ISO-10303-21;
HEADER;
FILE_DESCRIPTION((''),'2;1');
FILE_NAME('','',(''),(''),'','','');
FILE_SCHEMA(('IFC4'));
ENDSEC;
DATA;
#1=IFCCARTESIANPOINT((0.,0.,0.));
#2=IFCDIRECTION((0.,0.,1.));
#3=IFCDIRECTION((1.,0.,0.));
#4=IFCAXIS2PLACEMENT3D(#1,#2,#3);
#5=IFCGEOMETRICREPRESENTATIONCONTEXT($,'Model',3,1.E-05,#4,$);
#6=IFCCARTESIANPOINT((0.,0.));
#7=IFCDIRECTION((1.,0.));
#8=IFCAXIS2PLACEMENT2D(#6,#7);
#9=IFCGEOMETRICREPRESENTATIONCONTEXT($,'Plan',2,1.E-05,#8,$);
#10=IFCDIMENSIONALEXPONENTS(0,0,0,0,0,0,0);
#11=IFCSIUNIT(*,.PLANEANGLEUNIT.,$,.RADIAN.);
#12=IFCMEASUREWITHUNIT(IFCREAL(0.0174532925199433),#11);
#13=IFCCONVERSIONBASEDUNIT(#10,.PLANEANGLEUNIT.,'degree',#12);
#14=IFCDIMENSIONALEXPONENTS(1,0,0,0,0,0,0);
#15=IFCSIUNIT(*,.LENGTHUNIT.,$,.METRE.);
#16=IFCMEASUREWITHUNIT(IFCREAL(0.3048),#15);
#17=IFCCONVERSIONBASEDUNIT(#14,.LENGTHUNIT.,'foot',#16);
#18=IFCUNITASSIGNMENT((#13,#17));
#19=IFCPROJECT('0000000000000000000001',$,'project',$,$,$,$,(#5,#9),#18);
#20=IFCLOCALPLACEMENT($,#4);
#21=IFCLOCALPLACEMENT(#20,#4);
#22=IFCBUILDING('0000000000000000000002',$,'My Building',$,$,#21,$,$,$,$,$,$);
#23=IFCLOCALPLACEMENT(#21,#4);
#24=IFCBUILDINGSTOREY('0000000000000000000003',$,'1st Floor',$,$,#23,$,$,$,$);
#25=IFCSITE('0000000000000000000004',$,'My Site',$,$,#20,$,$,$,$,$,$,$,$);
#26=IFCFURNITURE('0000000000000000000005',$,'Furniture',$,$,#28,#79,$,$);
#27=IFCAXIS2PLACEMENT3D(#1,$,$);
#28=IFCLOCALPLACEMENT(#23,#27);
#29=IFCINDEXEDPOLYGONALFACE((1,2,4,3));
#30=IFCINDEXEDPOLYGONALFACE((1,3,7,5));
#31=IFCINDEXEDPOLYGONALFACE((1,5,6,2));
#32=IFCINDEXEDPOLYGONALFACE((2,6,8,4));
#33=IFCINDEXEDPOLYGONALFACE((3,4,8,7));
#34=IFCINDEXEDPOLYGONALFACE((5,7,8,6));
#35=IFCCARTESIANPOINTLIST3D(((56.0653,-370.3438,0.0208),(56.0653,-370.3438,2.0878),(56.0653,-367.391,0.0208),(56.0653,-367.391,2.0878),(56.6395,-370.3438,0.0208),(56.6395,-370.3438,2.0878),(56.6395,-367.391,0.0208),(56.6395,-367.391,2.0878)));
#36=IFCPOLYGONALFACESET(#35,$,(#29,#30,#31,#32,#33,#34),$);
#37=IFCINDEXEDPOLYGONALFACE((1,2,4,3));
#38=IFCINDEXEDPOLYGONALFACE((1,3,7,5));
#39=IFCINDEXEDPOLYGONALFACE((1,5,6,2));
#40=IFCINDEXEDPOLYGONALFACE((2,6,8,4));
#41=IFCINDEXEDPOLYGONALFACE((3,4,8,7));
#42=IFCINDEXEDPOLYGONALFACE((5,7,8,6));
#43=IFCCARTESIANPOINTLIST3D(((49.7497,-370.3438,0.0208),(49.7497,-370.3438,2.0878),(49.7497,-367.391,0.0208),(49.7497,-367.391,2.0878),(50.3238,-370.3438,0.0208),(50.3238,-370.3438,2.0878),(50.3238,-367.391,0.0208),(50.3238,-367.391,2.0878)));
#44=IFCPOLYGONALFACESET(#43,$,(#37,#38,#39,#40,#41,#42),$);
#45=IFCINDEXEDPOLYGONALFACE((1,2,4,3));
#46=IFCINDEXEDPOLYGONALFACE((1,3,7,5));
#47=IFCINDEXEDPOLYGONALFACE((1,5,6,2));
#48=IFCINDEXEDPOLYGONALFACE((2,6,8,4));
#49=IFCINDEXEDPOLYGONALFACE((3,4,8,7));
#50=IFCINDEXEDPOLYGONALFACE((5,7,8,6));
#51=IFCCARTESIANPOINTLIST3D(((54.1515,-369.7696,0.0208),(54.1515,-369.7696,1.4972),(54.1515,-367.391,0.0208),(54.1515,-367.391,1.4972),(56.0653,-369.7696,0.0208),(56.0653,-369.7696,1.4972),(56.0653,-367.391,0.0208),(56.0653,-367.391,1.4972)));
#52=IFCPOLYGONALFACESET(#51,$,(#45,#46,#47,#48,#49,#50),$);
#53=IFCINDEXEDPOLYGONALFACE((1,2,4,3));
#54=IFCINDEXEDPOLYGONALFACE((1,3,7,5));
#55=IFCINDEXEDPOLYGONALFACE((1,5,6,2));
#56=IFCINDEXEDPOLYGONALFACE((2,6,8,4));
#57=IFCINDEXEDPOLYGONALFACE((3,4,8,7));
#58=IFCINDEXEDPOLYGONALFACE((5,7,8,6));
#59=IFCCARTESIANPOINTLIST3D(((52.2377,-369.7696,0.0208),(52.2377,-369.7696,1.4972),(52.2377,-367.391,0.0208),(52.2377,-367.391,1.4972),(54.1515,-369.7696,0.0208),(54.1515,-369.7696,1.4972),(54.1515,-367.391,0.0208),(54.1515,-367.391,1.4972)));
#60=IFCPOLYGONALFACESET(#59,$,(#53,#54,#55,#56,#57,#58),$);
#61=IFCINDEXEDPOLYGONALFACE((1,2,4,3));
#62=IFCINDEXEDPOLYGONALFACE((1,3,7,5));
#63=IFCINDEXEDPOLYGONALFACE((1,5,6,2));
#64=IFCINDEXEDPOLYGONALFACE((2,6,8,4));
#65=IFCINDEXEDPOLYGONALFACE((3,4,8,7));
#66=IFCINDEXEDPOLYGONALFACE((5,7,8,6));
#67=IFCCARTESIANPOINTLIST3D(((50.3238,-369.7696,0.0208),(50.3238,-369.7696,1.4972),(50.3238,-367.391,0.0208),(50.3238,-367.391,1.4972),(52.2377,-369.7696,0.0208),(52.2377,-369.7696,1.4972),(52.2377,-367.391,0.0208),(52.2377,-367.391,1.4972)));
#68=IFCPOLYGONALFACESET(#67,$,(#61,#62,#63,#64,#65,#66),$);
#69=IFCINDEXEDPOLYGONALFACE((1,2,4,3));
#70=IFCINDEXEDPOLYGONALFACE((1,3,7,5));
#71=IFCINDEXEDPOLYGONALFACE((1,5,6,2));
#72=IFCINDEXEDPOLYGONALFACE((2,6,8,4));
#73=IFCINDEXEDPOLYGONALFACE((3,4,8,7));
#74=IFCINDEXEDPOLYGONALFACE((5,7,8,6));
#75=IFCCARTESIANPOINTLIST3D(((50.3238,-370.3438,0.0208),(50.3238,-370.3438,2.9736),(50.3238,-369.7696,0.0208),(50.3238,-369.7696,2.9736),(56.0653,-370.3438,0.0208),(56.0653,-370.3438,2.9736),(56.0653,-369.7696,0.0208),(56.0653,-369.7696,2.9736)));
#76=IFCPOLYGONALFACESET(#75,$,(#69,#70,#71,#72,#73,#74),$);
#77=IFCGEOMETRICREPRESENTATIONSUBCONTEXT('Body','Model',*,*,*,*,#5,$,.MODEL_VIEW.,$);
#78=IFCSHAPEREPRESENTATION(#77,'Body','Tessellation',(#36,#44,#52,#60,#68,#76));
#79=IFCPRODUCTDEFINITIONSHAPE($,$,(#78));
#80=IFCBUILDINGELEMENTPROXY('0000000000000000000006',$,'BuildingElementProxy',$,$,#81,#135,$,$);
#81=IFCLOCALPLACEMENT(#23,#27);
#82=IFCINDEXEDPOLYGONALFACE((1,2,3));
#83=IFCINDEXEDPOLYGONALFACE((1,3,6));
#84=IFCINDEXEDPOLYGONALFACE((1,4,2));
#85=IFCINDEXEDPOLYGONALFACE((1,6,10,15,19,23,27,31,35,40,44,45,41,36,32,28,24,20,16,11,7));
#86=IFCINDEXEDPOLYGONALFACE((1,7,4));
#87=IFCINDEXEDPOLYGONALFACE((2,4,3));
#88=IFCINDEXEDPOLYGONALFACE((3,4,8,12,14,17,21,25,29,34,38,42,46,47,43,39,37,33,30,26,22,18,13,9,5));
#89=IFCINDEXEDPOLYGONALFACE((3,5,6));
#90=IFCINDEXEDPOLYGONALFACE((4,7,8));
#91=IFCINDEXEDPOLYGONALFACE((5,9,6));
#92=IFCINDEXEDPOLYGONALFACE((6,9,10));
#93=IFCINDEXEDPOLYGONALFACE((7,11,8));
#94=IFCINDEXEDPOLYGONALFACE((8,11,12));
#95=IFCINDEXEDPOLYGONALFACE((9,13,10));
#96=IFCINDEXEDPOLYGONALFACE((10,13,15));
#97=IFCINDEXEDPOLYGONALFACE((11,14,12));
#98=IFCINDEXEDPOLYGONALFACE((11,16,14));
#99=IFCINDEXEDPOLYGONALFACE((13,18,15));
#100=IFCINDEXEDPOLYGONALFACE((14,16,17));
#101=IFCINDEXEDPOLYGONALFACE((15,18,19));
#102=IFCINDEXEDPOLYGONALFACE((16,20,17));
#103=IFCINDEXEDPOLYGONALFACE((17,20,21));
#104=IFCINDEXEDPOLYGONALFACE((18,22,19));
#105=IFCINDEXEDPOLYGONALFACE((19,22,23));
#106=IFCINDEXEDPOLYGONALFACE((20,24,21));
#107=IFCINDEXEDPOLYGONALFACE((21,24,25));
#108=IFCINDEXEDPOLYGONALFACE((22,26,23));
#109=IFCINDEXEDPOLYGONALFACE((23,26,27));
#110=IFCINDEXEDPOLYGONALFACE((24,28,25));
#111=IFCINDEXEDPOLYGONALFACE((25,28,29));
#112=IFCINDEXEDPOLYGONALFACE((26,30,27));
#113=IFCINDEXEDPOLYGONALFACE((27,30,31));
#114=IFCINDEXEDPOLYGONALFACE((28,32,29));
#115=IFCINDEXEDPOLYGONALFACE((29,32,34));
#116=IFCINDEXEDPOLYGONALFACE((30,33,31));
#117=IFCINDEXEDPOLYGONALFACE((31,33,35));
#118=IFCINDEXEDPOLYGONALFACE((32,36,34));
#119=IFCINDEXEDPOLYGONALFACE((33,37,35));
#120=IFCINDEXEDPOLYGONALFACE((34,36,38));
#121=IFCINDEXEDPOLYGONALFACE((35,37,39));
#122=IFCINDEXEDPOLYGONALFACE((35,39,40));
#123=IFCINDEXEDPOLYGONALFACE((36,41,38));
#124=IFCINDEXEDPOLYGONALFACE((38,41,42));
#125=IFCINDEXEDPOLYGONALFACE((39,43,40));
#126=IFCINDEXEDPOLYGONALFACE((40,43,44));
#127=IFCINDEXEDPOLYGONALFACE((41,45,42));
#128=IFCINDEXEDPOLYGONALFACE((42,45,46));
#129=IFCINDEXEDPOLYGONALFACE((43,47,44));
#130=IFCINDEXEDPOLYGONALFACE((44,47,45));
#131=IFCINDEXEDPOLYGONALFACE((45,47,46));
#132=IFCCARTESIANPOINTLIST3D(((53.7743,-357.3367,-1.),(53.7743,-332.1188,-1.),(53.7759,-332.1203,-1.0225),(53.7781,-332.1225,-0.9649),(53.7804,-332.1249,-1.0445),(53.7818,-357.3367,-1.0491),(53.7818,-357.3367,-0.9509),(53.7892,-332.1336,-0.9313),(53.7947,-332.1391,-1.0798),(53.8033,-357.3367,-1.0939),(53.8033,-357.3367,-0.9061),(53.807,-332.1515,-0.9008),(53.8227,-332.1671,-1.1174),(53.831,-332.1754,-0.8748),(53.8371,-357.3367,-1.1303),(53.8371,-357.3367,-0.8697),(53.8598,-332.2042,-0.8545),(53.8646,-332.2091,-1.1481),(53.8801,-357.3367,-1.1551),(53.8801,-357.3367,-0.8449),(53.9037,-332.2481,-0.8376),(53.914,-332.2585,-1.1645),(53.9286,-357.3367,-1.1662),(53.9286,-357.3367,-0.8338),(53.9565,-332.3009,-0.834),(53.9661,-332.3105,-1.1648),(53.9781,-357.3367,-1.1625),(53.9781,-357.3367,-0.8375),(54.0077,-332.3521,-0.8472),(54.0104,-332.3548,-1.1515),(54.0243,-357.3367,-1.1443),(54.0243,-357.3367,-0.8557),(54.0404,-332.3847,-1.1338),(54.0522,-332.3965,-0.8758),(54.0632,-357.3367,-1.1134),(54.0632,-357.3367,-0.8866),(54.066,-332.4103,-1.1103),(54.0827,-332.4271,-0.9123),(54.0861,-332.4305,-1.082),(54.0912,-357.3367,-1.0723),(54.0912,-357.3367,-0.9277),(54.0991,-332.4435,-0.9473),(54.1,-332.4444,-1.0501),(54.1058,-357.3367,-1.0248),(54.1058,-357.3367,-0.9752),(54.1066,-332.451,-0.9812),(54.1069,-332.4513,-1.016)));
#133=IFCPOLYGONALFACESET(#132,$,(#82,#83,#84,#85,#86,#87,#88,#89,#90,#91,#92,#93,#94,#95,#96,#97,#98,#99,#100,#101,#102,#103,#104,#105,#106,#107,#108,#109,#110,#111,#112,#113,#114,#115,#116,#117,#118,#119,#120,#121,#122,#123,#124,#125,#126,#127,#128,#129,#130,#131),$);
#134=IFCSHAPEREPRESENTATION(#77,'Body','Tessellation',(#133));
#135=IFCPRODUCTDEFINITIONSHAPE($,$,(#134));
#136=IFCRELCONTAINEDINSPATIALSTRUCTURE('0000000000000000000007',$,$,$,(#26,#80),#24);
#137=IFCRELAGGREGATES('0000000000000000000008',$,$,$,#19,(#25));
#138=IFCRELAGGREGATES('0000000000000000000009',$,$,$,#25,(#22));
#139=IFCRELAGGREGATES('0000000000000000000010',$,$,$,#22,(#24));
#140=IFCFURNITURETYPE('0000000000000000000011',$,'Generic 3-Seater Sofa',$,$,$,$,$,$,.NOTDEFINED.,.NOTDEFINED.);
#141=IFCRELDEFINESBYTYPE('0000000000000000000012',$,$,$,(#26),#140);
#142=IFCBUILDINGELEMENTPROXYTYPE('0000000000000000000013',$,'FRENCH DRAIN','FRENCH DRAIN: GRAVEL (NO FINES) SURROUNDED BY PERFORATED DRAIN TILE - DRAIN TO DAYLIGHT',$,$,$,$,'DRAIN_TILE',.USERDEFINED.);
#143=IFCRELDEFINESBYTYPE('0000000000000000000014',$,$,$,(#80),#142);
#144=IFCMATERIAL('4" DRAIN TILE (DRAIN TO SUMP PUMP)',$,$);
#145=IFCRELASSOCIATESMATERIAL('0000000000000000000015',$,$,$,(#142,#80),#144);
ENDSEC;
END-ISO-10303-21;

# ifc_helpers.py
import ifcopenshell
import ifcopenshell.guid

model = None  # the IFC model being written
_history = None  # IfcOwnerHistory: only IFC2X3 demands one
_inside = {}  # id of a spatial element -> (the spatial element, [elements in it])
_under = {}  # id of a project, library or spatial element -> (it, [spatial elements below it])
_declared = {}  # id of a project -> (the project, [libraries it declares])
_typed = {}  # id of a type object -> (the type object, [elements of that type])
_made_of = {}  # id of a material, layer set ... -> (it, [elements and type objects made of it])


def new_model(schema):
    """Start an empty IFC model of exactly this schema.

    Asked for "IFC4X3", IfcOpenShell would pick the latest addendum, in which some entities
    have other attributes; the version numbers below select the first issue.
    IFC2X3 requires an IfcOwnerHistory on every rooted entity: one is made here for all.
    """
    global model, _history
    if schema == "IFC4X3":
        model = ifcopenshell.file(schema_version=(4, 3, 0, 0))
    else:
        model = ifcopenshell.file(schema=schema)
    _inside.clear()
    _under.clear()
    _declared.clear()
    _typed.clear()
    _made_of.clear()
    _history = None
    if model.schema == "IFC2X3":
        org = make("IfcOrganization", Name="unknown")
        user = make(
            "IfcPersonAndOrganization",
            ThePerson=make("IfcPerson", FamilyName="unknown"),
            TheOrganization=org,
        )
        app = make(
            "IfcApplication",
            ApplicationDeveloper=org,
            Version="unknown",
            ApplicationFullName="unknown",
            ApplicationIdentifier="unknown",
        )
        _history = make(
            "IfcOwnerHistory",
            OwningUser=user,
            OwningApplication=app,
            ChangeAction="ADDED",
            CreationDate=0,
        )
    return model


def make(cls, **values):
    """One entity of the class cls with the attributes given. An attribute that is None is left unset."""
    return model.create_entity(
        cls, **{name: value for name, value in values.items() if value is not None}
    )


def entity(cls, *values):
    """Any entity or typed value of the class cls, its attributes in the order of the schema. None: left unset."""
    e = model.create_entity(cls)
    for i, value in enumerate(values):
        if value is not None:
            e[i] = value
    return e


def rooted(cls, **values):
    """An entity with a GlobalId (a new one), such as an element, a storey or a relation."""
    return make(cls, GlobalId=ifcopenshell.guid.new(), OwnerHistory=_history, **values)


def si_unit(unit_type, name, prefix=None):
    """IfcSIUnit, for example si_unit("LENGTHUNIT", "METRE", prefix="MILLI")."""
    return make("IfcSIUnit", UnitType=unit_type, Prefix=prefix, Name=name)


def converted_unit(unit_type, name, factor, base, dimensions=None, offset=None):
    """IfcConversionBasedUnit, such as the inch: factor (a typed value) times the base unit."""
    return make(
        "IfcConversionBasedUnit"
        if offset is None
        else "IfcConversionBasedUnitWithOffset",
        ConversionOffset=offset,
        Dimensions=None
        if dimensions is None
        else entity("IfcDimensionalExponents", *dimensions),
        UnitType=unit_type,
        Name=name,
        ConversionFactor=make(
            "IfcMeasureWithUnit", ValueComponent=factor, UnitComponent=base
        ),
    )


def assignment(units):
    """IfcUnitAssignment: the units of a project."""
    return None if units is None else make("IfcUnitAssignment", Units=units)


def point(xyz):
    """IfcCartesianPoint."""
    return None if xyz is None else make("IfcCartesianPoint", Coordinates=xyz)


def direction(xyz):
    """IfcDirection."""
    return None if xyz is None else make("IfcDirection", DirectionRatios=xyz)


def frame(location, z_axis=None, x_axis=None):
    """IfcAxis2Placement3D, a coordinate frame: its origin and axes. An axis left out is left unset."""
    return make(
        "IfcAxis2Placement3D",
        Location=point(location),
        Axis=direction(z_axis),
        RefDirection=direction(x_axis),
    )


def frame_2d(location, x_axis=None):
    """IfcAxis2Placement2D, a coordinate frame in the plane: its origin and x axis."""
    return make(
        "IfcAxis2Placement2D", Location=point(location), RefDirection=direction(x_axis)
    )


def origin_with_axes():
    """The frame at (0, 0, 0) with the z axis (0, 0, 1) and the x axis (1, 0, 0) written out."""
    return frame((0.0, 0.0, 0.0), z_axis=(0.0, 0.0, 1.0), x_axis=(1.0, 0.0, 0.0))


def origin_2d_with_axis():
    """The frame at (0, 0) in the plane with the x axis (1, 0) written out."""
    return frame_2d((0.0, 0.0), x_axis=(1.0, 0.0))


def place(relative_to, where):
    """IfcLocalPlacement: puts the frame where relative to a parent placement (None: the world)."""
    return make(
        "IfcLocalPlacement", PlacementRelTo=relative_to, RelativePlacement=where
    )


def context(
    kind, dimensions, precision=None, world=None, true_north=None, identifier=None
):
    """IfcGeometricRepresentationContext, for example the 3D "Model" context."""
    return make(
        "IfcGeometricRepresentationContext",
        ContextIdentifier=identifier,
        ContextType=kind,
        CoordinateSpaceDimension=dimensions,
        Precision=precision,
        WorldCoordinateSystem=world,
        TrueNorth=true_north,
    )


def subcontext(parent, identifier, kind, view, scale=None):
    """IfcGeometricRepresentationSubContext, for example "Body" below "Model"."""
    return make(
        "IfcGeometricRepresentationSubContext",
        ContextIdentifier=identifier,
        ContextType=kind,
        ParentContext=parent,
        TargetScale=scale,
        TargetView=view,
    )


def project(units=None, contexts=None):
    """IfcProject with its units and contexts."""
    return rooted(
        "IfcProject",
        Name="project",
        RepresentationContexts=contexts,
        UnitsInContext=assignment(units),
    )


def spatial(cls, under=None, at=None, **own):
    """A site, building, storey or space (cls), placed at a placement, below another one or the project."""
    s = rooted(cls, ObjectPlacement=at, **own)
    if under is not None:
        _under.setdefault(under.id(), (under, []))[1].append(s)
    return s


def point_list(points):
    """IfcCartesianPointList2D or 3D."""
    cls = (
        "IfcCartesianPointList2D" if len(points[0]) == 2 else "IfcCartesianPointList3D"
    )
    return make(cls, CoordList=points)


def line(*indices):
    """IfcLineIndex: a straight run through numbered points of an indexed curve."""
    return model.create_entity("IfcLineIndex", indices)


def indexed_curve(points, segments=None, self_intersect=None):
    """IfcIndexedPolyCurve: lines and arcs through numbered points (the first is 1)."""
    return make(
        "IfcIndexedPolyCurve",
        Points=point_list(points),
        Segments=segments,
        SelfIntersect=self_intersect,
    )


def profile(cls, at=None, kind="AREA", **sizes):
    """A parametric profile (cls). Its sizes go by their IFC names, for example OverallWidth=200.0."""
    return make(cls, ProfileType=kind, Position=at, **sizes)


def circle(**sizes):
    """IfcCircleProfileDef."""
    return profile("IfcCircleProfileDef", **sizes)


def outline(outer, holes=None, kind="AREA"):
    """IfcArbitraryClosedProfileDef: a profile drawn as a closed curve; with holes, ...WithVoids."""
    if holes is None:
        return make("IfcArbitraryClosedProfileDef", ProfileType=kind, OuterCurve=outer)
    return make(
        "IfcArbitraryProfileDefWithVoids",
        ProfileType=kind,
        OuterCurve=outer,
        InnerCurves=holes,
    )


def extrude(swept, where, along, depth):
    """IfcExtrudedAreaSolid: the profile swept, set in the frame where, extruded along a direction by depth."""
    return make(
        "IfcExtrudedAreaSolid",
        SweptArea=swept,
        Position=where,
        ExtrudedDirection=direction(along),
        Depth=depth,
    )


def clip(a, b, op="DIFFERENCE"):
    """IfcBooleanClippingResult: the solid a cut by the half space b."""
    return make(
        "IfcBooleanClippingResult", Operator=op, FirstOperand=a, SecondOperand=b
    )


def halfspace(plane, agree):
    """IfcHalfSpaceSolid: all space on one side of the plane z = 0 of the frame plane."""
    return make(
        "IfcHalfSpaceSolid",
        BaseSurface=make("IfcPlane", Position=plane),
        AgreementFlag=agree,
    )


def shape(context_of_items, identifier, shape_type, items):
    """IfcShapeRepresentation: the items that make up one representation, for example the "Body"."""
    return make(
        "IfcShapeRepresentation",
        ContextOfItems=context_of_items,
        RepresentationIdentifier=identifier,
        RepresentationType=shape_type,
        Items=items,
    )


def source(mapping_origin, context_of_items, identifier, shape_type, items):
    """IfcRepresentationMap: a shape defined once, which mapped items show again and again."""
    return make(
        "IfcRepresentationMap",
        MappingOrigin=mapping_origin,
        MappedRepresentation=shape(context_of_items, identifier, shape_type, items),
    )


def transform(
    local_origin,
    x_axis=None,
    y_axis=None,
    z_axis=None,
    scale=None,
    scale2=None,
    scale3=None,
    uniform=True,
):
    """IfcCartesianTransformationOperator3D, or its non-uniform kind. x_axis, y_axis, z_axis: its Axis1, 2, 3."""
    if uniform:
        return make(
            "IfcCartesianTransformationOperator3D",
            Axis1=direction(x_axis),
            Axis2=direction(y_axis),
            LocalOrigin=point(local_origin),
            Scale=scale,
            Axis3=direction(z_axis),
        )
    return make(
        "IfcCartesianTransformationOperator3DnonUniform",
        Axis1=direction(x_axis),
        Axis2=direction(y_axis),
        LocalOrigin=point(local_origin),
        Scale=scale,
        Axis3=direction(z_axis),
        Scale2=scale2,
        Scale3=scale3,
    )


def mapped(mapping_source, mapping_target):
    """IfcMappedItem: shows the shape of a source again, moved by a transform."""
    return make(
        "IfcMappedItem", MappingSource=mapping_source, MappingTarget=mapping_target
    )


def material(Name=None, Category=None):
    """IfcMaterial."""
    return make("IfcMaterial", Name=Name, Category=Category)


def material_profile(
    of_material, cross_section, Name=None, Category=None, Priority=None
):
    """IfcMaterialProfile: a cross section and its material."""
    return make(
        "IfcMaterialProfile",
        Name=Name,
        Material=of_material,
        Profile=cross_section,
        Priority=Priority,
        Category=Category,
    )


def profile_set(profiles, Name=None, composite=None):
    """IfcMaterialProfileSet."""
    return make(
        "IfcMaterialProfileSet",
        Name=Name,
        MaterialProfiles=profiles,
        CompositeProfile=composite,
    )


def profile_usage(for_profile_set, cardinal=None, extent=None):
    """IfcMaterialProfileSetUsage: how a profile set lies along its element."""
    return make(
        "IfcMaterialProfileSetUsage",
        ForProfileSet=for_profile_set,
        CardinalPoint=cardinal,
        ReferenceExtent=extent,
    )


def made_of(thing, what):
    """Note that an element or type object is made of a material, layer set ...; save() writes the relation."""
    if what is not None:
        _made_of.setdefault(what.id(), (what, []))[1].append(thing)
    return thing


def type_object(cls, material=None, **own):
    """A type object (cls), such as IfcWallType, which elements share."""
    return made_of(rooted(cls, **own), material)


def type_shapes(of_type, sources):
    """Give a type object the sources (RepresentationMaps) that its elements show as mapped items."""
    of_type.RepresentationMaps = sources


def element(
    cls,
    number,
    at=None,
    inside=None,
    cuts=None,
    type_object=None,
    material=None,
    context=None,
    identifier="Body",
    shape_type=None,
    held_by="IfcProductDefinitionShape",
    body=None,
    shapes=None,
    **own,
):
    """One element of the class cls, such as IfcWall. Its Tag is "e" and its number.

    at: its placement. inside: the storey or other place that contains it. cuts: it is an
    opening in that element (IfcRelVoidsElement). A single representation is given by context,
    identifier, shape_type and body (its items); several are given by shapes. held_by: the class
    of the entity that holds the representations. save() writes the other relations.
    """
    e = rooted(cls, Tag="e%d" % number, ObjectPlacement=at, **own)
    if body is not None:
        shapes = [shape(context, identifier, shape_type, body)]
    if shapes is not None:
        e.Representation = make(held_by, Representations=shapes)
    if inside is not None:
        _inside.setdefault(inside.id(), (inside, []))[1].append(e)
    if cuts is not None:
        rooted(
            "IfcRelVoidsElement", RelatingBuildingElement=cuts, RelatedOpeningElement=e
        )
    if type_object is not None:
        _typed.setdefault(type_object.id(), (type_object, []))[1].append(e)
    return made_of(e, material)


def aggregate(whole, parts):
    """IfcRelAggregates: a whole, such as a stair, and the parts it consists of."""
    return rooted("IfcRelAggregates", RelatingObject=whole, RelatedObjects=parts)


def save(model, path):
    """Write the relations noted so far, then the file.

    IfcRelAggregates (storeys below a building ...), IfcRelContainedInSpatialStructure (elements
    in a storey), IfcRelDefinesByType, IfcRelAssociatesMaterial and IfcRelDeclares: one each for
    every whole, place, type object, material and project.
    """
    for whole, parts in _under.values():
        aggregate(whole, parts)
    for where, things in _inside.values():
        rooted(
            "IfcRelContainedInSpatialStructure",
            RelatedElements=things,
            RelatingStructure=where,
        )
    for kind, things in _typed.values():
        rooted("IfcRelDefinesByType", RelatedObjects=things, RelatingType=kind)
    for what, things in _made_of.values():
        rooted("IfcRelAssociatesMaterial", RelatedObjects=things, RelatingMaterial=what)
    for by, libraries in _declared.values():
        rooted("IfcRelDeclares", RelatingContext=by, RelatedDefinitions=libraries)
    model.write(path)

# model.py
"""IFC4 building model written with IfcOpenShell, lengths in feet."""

from ifc_helpers import new_model, entity, si_unit, converted_unit, frame, origin_with_axes, origin_2d_with_axis, place, context, subcontext, project, spatial, line, indexed_curve, circle, outline, extrude, clip, halfspace, source, transform, mapped, material, material_profile, profile_set, profile_usage, type_object, type_shapes, element, save


model = new_model("IFC4")

# Units and contexts
model_context = context("Model", 3, precision=1e-05, world=origin_with_axes())
plan_context = context("Plan", 2, precision=1e-05, world=origin_2d_with_axis())
body_context = subcontext(model_context, "Body", "Model", "MODEL_VIEW")
ifc_project = project(units=[converted_unit("PLANEANGLEUNIT", "degree", entity("IfcReal", 0.0174532925199433), si_unit("PLANEANGLEUNIT", "RADIAN"), dimensions=[0, 0, 0, 0, 0, 0, 0]), converted_unit("LENGTHUNIT", "foot", entity("IfcReal", 0.3048), si_unit("LENGTHUNIT", "METRE"), dimensions=[1, 0, 0, 0, 0, 0, 0])], contexts=[model_context, plan_context])

# Site, building, storey
site_placement = place(None, origin_with_axes())
site = spatial("IfcSite", under=ifc_project, at=site_placement, Name="My Site")
building_placement = place(site_placement, origin_with_axes())
building = spatial("IfcBuilding", under=site, at=building_placement, Name="My Building")
storey_placement = place(building_placement, origin_with_axes())
storey = spatial("IfcBuildingStorey", under=building, at=storey_placement, Name="1st Floor")

# Furniture
furniture_type_1 = type_object("IfcFurnitureType", Name="Generic 3-Seater Sofa", AssemblyPlace="NOTDEFINED", PredefinedType="NOTDEFINED")
shared_shape = source(origin_with_axes(), body_context, "Body", "SweptSolid", [
    extrude(outline(indexed_curve([(0.0, 0.0), (0.5741, 0.0), (0.5741, 2.9528), (0.0, 2.9528)], segments=[line(1, 2), line(2, 3), line(3, 4), line(4, 1)])), frame((-3.4449, -2.9528, 0.0), z_axis=(0.0, 0.0, 1.0), x_axis=(1.0, 0.0, 0.0)), (0.0, 0.0, 1.0), 2.0669),
    extrude(outline(indexed_curve([(0.0, 0.0), (0.5741, 0.0), (0.5741, 2.9528), (0.0, 2.9528)], segments=[line(1, 2), line(2, 3), line(3, 4), line(4, 1)])), frame((2.8707, -2.9528, 0.0), z_axis=(0.0, 0.0, 1.0), x_axis=(1.0, 0.0, 0.0)), (0.0, 0.0, 1.0), 2.0669),
    extrude(outline(indexed_curve([(0.5741, 0.0), (2.488, 0.0), (2.488, 2.3786), (0.5741, 2.3786)], segments=[line(1, 2), line(2, 3), line(3, 4), line(4, 1)])), frame((-3.4449, -2.9528, 0.0), z_axis=(0.0, 0.0, 1.0), x_axis=(1.0, 0.0, 0.0)), (0.0, 0.0, 1.0), 1.4764),
    extrude(outline(indexed_curve([(2.488, 0.0), (4.4018, 0.0), (4.4018, 2.3786), (2.488, 2.3786)], segments=[line(1, 2), line(2, 3), line(3, 4), line(4, 1)])), frame((-3.4449, -2.9528, 0.0), z_axis=(0.0, 0.0, 1.0), x_axis=(1.0, 0.0, 0.0)), (0.0, 0.0, 1.0), 1.4764),
    extrude(outline(indexed_curve([(4.4018, 0.0), (6.3156, 0.0), (6.3156, 2.3786), (4.4018, 2.3786)], segments=[line(1, 2), line(2, 3), line(3, 4), line(4, 1)])), frame((-3.4449, -2.9528, 0.0), z_axis=(0.0, 0.0, 1.0), x_axis=(1.0, 0.0, 0.0)), (0.0, 0.0, 1.0), 1.4764),
    extrude(outline(indexed_curve([(0.5741, 2.3786), (6.3156, 2.3786), (6.3156, 2.9528), (0.5741, 2.9528)], segments=[line(1, 2), line(2, 3), line(3, 4), line(4, 1)])), frame((-3.4449, -2.9528, 0.0), z_axis=(0.0, 0.0, 1.0), x_axis=(1.0, 0.0, 0.0)), (0.0, 0.0, 1.0), 2.9528),
])
type_shapes(furniture_type_1, [shared_shape])
furniture_1_placement = place(storey_placement, frame((53.1946, -370.3438, 0.0208), z_axis=(0.0, 0.0, 1.0), x_axis=(-1.0, 0.0, 0.0)))
element("IfcFurniture", 1, at=furniture_1_placement, inside=storey, type_object=furniture_type_1, Name="Furniture", context=body_context, shape_type="MappedRepresentation", body=[
    mapped(shared_shape, transform((0.0, 0.0, 0.0), x_axis=(1.0, 0.0, 0.0), y_axis=(0.0, 1.0, 0.0), z_axis=(0.0, 0.0, 1.0), scale=1.0)),
])

# Building element proxy
ifc_material_1 = material(Name="4\" DRAIN TILE (DRAIN TO SUMP PUMP)")
ifc_material_profile_1 = material_profile(ifc_material_1, circle(Radius=0.1667, kind="CURVE"), Name="profile name")
ifc_profile_set_1 = profile_set([ifc_material_profile_1], Name="this is name of the profile set")
ifc_profile_usage_1 = profile_usage(ifc_profile_set_1, cardinal=5)
building_element_proxy_type = type_object("IfcBuildingElementProxyType", Name="FRENCH DRAIN", Description="FRENCH DRAIN: GRAVEL (NO FINES) SURROUNDED BY PERFORATED DRAIN TILE - DRAIN TO DAYLIGHT", ElementType="DRAIN_TILE", PredefinedType="USERDEFINED", material=ifc_profile_set_1)
proxy_1_placement = place(storey_placement, frame((53.941, -357.3367, -1.0), z_axis=(0.0, 1.0, 0.0), x_axis=(-1.0, 0.0, 0.0)))
element("IfcBuildingElementProxy", 2, at=proxy_1_placement, inside=storey, type_object=building_element_proxy_type, material=ifc_profile_usage_1, Name="BuildingElementProxy", context=body_context, shape_type="Clipping", body=[
    clip(extrude(circle(Radius=0.1667, kind="CURVE"), origin_with_axes(), (0.0, 0.0, 1.0), 25.218), halfspace(frame((0.1667, 1.0, 25.2179), z_axis=(-0.707027, 0.0, 0.707186), x_axis=(0.0, 1.0, 0.0)), False)),
])

save(model, "model.ifc")
